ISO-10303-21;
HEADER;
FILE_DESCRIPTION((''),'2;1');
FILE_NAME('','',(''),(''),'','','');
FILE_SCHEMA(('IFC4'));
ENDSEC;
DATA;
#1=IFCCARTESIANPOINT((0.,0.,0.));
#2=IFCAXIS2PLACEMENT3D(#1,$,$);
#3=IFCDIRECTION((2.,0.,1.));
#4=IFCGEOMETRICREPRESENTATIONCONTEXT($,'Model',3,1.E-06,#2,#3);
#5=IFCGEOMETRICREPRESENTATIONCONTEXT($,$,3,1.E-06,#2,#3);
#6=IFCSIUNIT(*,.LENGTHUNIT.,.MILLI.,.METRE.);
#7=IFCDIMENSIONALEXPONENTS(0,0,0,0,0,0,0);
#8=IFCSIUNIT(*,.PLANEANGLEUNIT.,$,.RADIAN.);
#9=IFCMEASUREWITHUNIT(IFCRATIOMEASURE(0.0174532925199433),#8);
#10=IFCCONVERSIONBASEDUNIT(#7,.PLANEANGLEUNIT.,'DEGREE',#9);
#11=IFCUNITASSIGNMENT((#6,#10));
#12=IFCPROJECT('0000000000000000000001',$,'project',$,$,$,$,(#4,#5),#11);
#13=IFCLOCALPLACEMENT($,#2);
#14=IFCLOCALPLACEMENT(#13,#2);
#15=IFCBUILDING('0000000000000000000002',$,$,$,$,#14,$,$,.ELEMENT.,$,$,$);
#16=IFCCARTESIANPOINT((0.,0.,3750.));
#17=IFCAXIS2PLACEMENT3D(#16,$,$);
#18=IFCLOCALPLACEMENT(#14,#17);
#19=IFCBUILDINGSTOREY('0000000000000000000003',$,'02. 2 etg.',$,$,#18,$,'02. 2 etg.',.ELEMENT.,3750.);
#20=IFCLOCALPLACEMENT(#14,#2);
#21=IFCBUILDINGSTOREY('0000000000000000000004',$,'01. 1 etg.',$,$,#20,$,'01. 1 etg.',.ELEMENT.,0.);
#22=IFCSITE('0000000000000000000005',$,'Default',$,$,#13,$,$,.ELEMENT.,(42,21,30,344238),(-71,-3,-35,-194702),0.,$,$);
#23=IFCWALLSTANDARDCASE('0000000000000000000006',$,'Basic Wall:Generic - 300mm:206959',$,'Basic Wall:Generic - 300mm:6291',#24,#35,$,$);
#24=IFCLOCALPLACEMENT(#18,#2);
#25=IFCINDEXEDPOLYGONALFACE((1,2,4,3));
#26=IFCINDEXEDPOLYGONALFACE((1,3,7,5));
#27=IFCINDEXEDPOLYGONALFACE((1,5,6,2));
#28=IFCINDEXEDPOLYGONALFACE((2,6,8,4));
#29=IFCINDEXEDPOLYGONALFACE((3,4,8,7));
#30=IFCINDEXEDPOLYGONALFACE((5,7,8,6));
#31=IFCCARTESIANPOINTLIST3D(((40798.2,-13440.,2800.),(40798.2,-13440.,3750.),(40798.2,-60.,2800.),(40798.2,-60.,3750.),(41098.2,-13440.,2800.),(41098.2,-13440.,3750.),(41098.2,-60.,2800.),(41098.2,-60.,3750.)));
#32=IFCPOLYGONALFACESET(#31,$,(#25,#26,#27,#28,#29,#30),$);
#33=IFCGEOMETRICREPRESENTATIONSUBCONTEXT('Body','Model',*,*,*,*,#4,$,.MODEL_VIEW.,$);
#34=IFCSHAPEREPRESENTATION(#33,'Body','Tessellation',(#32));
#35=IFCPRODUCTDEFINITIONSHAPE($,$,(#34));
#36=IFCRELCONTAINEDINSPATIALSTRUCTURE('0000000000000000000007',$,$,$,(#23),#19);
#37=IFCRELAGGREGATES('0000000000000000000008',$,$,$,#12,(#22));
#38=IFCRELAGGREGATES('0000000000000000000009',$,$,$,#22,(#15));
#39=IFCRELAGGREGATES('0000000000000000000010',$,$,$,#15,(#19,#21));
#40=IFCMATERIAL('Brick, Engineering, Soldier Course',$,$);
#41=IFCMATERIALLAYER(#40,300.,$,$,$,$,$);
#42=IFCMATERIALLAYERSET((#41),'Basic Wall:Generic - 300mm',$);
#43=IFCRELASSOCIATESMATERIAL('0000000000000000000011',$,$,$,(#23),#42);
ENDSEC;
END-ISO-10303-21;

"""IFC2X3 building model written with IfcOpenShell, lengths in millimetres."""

from ifc_helpers import new_model, entity, si_unit, converted_unit, direction, frame, frame_2d, origin, place, context, subcontext, project, spatial, rectangle, extrude, material, layer, layer_set, layer_usage, element, save


model = new_model("IFC2X3")

# Units and contexts
model_context = context("Model", 3, precision=1e-06, world=origin(), true_north=direction((2.0, 0.0, 1.0)))
context_of_model = context(None, 3, precision=1e-06, world=origin(), true_north=direction((2.0, 0.0, 1.0)))
body_context = subcontext(model_context, "Body", "Model", "MODEL_VIEW")
ifc_project = project(units=[si_unit("LENGTHUNIT", "METRE", prefix="MILLI"), converted_unit("PLANEANGLEUNIT", "DEGREE", entity("IfcRatioMeasure", 0.0174532925199433), si_unit("PLANEANGLEUNIT", "RADIAN"), dimensions=[0, 0, 0, 0, 0, 0, 0])], contexts=[model_context, context_of_model])

# Site, building, storey
site_placement = place(None, origin())
site = spatial("IfcSite", under=ifc_project, at=site_placement, Name="Default", CompositionType="ELEMENT", RefLatitude=(42, 21, 30, 344238), RefLongitude=(-71, -3, -35, -194702), RefElevation=0.0)
building_placement = place(site_placement, origin())
building = spatial("IfcBuilding", under=site, at=building_placement, CompositionType="ELEMENT")
storey_1_placement = place(building_placement, frame((0.0, 0.0, 3750.0)))
storey_1 = spatial("IfcBuildingStorey", under=building, at=storey_1_placement, Name="02. 2 etg.", LongName="02. 2 etg.", CompositionType="ELEMENT", Elevation=3750.0)

# Shared definitions
storey_2_placement = place(building_placement, origin())

# Shared definitions
ifc_material_1 = material(Name="Brick, Engineering, Soldier Course")
ifc_layer_1 = layer(ifc_material_1, 300.0)
ifc_layer_set_1 = layer_set([ifc_layer_1], Name="Basic Wall:Generic - 300mm")

# Shared definitions
storey_2 = spatial("IfcBuildingStorey", under=building, at=storey_2_placement, Name="01. 1 etg.", LongName="01. 1 etg.", CompositionType="ELEMENT", Elevation=0.0)

# Wall
ifc_layer_usage_1 = layer_usage(ifc_layer_set_1, "AXIS2", "POSITIVE", -150.0)
wall_1_placement = place(storey_1_placement, frame((40948.2, -60.0, 2800.0), z_axis=(0.0, 0.0, 1.0), x_axis=(0.0, -1.0, 0.0)))
element("IfcWallStandardCase", 1, at=wall_1_placement, inside=storey_1, material=ifc_layer_usage_1, Name="Basic Wall:Generic - 300mm:206959", ObjectType="Basic Wall:Generic - 300mm:6291", context=body_context, shape_type="SweptSolid", body=[
    extrude(rectangle(XDim=13380.0, YDim=300.0, at=frame_2d((6690.0, 0.0), x_axis=(-1.0, 0.0))), origin(), (0.0, 0.0, 1.0), 950.0),
])

save(model, "model.ifc")
